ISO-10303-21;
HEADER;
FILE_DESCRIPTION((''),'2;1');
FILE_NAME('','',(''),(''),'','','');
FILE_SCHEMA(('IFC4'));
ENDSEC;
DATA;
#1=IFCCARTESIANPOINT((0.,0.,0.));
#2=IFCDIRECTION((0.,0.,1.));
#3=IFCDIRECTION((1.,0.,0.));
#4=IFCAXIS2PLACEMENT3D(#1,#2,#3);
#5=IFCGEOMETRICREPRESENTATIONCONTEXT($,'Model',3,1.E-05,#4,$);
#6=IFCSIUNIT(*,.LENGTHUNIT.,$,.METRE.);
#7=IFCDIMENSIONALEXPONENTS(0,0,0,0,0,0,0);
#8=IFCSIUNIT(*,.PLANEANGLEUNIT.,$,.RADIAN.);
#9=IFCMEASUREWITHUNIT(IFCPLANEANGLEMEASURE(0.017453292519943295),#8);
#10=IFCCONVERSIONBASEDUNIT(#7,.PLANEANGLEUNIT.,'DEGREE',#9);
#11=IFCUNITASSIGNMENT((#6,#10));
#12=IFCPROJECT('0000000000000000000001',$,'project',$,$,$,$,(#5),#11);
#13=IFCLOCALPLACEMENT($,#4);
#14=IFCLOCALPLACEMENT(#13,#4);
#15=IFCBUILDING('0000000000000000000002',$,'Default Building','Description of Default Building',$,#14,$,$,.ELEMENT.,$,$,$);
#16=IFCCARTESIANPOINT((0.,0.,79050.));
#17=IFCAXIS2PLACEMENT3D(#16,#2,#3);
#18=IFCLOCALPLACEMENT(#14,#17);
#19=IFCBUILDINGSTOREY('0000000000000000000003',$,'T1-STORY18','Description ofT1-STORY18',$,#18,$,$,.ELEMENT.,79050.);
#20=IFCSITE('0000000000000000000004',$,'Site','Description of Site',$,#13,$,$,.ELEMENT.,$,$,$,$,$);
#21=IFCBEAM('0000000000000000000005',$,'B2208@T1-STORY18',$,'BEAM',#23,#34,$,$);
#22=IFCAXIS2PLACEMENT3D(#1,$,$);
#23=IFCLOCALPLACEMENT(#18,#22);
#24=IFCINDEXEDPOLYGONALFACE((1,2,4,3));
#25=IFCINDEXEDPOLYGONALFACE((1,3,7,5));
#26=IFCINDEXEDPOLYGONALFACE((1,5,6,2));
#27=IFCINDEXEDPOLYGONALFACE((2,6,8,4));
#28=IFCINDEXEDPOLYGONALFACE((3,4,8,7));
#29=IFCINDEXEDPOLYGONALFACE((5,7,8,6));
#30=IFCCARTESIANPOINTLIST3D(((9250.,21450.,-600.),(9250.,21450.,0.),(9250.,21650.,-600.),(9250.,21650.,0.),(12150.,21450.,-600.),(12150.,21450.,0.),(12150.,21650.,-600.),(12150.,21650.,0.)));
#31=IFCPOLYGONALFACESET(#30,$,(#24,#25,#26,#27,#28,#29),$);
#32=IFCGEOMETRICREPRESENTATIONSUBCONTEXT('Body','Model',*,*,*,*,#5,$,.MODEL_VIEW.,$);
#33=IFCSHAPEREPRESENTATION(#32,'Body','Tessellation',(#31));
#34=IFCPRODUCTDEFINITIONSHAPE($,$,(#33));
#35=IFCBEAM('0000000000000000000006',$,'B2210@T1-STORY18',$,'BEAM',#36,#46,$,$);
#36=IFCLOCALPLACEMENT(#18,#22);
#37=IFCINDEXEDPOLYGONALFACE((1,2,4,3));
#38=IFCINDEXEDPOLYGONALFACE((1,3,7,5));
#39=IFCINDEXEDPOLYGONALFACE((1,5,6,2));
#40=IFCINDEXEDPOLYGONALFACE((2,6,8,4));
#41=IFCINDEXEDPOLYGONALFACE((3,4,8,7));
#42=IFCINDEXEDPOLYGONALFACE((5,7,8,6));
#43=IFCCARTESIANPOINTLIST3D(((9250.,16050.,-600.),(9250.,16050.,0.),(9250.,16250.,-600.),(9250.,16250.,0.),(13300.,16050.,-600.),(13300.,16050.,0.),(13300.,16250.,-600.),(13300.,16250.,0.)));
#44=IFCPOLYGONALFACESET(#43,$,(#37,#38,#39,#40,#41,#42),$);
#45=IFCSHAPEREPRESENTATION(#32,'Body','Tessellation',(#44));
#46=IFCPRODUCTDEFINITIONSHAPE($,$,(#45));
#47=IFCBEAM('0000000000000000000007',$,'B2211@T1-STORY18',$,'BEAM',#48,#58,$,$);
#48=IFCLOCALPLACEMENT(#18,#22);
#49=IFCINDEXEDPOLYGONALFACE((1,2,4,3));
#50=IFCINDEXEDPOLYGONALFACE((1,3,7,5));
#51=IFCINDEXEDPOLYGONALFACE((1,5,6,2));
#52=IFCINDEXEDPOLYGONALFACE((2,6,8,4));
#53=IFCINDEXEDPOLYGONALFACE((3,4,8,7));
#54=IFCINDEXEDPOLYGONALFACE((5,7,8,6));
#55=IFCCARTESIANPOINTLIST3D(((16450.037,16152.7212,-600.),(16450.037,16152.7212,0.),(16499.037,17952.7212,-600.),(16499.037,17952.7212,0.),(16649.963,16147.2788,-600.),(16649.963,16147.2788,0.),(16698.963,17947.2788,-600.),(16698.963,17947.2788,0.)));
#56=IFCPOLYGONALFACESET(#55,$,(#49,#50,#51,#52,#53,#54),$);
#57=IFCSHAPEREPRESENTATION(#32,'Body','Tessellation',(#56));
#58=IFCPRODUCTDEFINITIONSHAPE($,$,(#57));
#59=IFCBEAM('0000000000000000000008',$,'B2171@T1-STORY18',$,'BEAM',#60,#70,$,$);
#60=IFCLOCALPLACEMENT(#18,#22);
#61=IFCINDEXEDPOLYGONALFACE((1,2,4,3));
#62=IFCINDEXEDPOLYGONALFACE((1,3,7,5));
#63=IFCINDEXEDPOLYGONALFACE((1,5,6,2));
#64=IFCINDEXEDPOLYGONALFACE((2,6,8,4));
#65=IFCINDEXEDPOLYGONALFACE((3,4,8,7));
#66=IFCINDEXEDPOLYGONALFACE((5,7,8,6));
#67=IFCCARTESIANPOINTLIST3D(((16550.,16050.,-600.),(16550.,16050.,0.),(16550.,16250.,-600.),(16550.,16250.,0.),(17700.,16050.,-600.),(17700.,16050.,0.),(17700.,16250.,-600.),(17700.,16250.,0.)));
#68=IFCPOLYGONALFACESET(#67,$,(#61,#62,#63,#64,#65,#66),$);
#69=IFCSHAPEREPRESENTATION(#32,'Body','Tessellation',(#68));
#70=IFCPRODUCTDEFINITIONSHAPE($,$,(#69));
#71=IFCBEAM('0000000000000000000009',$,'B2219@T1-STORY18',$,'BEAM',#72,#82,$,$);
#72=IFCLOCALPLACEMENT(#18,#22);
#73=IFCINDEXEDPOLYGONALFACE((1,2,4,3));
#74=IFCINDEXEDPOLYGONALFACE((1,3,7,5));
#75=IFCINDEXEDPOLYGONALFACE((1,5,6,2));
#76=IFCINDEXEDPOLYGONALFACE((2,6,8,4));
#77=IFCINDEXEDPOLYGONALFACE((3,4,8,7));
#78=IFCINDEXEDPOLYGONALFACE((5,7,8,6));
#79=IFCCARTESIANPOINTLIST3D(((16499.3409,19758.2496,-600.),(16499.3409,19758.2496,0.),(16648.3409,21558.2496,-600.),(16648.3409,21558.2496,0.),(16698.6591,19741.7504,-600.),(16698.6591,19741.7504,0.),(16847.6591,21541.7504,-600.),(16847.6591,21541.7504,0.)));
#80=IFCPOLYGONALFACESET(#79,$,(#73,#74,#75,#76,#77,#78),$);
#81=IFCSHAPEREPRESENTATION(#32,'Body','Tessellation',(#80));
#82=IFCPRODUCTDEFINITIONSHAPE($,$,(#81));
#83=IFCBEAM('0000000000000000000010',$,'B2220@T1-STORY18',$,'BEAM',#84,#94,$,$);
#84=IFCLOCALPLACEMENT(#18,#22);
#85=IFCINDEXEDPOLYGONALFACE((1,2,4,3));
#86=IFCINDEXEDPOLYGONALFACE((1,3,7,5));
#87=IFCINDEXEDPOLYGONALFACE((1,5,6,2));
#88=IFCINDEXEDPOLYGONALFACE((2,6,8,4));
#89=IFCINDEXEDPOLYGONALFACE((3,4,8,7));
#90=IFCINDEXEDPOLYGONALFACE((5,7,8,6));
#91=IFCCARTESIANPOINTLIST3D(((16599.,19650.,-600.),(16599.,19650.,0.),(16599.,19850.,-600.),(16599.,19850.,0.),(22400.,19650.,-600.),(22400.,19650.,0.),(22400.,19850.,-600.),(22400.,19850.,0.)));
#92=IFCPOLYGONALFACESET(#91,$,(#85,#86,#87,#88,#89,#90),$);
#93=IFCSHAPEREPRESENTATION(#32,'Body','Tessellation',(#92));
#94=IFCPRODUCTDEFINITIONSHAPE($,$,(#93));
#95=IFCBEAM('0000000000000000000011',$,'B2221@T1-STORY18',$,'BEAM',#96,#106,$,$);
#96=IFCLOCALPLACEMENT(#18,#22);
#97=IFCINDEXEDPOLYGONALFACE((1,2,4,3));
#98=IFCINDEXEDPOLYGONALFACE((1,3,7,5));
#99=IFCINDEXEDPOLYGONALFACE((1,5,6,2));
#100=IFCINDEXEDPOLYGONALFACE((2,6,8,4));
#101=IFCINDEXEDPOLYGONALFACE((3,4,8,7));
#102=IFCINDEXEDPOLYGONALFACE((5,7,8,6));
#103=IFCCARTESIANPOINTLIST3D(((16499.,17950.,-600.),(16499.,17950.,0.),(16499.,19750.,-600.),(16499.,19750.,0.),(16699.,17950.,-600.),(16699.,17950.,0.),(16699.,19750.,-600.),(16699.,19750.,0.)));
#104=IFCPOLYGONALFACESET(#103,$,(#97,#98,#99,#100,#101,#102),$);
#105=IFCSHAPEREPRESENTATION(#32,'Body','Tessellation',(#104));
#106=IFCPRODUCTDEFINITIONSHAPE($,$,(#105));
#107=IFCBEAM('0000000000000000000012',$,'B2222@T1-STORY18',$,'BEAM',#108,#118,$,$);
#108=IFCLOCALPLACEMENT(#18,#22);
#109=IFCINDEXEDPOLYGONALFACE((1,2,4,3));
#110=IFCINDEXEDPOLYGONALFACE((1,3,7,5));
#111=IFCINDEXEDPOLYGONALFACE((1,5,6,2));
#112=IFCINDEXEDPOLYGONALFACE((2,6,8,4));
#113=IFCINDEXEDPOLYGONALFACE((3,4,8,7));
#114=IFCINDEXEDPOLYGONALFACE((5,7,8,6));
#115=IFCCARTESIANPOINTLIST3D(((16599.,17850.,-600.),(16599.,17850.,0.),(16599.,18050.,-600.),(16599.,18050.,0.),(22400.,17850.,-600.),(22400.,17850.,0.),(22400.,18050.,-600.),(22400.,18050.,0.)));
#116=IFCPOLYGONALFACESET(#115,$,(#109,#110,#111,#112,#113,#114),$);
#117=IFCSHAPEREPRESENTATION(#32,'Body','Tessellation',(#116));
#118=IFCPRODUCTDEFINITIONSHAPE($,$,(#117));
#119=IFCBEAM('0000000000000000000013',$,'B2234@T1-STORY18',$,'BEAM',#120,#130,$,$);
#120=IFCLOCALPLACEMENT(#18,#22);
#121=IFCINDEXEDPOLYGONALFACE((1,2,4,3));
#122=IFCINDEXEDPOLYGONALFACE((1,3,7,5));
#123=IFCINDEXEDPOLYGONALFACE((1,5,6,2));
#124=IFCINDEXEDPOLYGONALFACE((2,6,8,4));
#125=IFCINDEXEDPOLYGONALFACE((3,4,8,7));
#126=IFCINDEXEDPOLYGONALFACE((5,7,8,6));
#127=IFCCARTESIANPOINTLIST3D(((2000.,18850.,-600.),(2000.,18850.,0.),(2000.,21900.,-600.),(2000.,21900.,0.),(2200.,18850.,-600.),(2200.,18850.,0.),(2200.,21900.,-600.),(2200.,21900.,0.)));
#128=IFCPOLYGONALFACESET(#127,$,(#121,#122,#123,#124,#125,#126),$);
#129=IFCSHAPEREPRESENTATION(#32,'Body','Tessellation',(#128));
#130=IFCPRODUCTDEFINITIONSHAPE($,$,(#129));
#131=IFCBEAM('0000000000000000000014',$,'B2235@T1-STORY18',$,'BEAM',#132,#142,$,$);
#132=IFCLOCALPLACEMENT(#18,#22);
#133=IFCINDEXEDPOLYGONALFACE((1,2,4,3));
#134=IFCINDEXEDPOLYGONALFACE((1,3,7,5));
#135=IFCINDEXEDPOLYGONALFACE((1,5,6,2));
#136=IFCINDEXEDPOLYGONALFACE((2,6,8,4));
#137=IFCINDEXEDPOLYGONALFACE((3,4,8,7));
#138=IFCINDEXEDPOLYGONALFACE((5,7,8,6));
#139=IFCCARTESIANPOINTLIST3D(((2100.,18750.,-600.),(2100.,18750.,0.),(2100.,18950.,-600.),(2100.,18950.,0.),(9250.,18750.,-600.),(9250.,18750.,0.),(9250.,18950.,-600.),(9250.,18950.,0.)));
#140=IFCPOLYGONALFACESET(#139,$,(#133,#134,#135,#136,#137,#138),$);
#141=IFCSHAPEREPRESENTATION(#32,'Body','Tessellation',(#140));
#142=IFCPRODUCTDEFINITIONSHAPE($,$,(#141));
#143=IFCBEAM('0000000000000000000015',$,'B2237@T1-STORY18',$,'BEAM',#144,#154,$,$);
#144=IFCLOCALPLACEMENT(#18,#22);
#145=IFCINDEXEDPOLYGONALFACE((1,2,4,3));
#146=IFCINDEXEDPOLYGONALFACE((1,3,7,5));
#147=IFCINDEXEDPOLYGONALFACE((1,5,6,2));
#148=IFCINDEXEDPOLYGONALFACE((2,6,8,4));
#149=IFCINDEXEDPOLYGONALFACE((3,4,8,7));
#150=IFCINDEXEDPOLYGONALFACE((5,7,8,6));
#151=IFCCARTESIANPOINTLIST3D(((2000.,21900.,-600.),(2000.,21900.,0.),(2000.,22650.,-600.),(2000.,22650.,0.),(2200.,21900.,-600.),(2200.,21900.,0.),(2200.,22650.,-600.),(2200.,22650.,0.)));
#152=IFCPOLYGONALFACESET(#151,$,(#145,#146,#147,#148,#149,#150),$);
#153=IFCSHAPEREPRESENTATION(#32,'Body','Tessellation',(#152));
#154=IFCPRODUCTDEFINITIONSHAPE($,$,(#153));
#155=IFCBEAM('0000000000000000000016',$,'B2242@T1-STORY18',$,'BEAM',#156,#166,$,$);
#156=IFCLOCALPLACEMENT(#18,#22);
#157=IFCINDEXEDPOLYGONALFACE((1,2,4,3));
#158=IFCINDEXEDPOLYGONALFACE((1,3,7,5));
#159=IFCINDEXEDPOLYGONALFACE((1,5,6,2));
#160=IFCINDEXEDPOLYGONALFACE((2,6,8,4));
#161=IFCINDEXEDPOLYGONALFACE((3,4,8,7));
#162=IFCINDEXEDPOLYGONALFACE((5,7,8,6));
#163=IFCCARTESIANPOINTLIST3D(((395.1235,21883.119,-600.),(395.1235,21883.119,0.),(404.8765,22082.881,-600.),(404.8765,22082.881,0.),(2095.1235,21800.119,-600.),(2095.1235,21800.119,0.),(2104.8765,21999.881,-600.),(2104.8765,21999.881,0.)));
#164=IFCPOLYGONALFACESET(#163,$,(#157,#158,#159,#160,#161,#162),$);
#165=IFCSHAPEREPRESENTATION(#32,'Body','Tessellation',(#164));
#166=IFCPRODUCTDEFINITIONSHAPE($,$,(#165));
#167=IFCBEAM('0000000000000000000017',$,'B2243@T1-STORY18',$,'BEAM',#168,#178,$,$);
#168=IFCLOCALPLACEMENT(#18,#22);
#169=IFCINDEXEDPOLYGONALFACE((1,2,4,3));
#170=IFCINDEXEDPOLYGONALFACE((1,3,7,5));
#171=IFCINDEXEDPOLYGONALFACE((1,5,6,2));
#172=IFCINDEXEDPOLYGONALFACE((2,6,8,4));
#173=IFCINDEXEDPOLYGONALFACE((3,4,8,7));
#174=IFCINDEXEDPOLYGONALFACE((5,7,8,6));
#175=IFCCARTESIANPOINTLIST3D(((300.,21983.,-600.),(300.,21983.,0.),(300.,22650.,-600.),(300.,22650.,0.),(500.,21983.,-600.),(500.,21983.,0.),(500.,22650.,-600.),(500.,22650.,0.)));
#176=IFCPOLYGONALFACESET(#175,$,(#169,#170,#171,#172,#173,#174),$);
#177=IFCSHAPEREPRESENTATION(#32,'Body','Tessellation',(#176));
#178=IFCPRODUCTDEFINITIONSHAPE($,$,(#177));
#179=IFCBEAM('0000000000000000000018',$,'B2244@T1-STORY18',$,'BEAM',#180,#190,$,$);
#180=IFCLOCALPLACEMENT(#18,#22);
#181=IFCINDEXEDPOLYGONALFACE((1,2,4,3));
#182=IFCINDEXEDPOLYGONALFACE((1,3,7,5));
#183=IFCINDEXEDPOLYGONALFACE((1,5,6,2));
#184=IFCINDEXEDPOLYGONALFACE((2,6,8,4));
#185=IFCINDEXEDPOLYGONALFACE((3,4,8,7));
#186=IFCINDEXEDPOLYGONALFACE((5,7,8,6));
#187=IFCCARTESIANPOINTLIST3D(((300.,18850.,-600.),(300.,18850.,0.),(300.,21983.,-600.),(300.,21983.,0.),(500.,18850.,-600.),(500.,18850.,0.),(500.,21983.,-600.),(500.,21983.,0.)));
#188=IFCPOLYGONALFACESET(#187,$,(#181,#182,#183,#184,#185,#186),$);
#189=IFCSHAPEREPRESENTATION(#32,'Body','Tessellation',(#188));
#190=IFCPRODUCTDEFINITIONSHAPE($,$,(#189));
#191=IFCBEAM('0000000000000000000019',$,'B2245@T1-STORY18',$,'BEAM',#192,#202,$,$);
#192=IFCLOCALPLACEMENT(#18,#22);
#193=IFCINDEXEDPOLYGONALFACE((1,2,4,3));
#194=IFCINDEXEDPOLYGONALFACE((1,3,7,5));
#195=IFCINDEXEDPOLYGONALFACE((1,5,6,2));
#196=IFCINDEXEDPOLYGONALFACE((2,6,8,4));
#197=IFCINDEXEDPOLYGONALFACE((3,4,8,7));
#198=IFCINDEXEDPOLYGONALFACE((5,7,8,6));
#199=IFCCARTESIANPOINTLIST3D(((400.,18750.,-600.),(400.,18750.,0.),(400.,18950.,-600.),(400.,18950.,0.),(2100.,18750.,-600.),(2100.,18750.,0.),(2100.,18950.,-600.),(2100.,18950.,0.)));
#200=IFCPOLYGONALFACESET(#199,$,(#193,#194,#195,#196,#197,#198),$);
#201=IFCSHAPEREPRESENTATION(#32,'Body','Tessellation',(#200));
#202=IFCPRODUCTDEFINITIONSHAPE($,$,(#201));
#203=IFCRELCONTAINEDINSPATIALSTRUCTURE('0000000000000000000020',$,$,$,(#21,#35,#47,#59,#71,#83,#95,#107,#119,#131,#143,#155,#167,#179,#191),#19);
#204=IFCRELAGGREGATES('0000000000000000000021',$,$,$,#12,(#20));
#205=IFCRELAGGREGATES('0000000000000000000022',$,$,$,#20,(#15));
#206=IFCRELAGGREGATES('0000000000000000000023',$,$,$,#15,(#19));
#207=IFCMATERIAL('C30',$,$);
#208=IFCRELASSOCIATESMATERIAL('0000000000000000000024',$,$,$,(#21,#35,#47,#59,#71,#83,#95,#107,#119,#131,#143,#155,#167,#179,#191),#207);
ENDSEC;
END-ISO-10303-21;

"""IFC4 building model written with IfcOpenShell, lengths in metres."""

from ifc_helpers import new_model, entity, si_unit, converted_unit, frame, origin_with_axes, place, context, subcontext, project, spatial, rectangle, extrude, material, element, save


model = new_model("IFC4")

# Units and contexts
model_context = context("Model", 3, precision=1e-05, world=origin_with_axes())
body_context = subcontext(model_context, "Body", "Model", "MODEL_VIEW")
ifc_project = project(units=[si_unit("LENGTHUNIT", "METRE"), converted_unit("PLANEANGLEUNIT", "DEGREE", entity("IfcPlaneAngleMeasure", 0.017453292519943295), si_unit("PLANEANGLEUNIT", "RADIAN"), dimensions=[0, 0, 0, 0, 0, 0, 0])], contexts=[model_context])

# Site, building, storey
site_placement = place(None, origin_with_axes())
site = spatial("IfcSite", under=ifc_project, at=site_placement, Name="Site", Description="Description of Site", CompositionType="ELEMENT")
building_placement = place(site_placement, origin_with_axes())
building = spatial("IfcBuilding", under=site, at=building_placement, Name="Default Building", Description="Description of Default Building", CompositionType="ELEMENT")
storey_placement = place(building_placement, frame((0.0, 0.0, 79050.0), z_axis=(0.0, 0.0, 1.0), x_axis=(1.0, 0.0, 0.0)))
storey = spatial("IfcBuildingStorey", under=building, at=storey_placement, Name="T1-STORY18", Description="Description ofT1-STORY18", CompositionType="ELEMENT", Elevation=79050.0)

# Beams
ifc_material_1 = material(Name="C30")
beam_1_placement = place(storey_placement, frame((9250.0, 21550.0, -300.0), z_axis=(1.0, 0.0, 0.0), x_axis=(0.0, 1.0, 0.0)))
element("IfcBeam", 1, at=beam_1_placement, inside=storey, material=ifc_material_1, Name="B2208@T1-STORY18", ObjectType="BEAM", context=body_context, shape_type="SweptSolid", body=[
    extrude(rectangle(XDim=200.0, YDim=600.0), origin_with_axes(), (0.0, 0.0, 1.0), 2900.0),
])
beam_2_placement = place(storey_placement, frame((9250.0, 16150.0, -300.0), z_axis=(1.0, 0.0, 0.0), x_axis=(0.0, 1.0, 0.0)))
element("IfcBeam", 2, at=beam_2_placement, inside=storey, material=ifc_material_1, Name="B2210@T1-STORY18", ObjectType="BEAM", context=body_context, shape_type="SweptSolid", body=[
    extrude(rectangle(XDim=200.0, YDim=600.0), origin_with_axes(), (0.0, 0.0, 1.0), 4050.0),
])
beam_3_placement = place(storey_placement, frame((16550.0, 16150.0, -300.0), z_axis=(0.027212, 0.99963, 0.0), x_axis=(-0.99963, 0.027212, 0.0)))
element("IfcBeam", 3, at=beam_3_placement, inside=storey, material=ifc_material_1, Name="B2211@T1-STORY18", ObjectType="BEAM", context=body_context, shape_type="SweptSolid", body=[
    extrude(rectangle(XDim=200.0, YDim=600.0), origin_with_axes(), (0.0, 0.0, 1.0), 1800.6668),
])
beam_4_placement = place(storey_placement, frame((16550.0, 16150.0, -300.0), z_axis=(1.0, 0.0, 0.0), x_axis=(0.0, 1.0, 0.0)))
element("IfcBeam", 4, at=beam_4_placement, inside=storey, material=ifc_material_1, Name="B2171@T1-STORY18", ObjectType="BEAM", context=body_context, shape_type="SweptSolid", body=[
    extrude(rectangle(XDim=200.0, YDim=600.0), origin_with_axes(), (0.0, 0.0, 1.0), 1150.0),
])
beam_5_placement = place(storey_placement, frame((16599.0, 19750.0, -300.0), z_axis=(0.082496, 0.996591, 0.0), x_axis=(-0.996591, 0.082496, 0.0)))
element("IfcBeam", 5, at=beam_5_placement, inside=storey, material=ifc_material_1, Name="B2219@T1-STORY18", ObjectType="BEAM", context=body_context, shape_type="SweptSolid", body=[
    extrude(rectangle(XDim=200.0, YDim=600.0), origin_with_axes(), (0.0, 0.0, 1.0), 1806.1564),
])
beam_6_placement = place(storey_placement, frame((16599.0, 19750.0, -300.0), z_axis=(1.0, 0.0, 0.0), x_axis=(0.0, 1.0, 0.0)))
element("IfcBeam", 6, at=beam_6_placement, inside=storey, material=ifc_material_1, Name="B2220@T1-STORY18", ObjectType="BEAM", context=body_context, shape_type="SweptSolid", body=[
    extrude(rectangle(XDim=200.0, YDim=600.0), origin_with_axes(), (0.0, 0.0, 1.0), 5801.0),
])
beam_7_placement = place(storey_placement, frame((16599.0, 17950.0, -300.0), z_axis=(0.0, 1.0, 0.0), x_axis=(-1.0, 0.0, 0.0)))
element("IfcBeam", 7, at=beam_7_placement, inside=storey, material=ifc_material_1, Name="B2221@T1-STORY18", ObjectType="BEAM", context=body_context, shape_type="SweptSolid", body=[
    extrude(rectangle(XDim=200.0, YDim=600.0), origin_with_axes(), (0.0, 0.0, 1.0), 1800.0),
])
beam_8_placement = place(storey_placement, frame((16599.0, 17950.0, -300.0), z_axis=(1.0, 0.0, 0.0), x_axis=(0.0, 1.0, 0.0)))
element("IfcBeam", 8, at=beam_8_placement, inside=storey, material=ifc_material_1, Name="B2222@T1-STORY18", ObjectType="BEAM", context=body_context, shape_type="SweptSolid", body=[
    extrude(rectangle(XDim=200.0, YDim=600.0), origin_with_axes(), (0.0, 0.0, 1.0), 5801.0),
])
beam_9_placement = place(storey_placement, frame((2100.0, 18850.0, -300.0), z_axis=(0.0, 1.0, 0.0), x_axis=(-1.0, 0.0, 0.0)))
element("IfcBeam", 9, at=beam_9_placement, inside=storey, material=ifc_material_1, Name="B2234@T1-STORY18", ObjectType="BEAM", context=body_context, shape_type="SweptSolid", body=[
    extrude(rectangle(XDim=200.0, YDim=600.0), origin_with_axes(), (0.0, 0.0, 1.0), 3050.0),
])
beam_10_placement = place(storey_placement, frame((2100.0, 18850.0, -300.0), z_axis=(1.0, 0.0, 0.0), x_axis=(0.0, 1.0, 0.0)))
element("IfcBeam", 10, at=beam_10_placement, inside=storey, material=ifc_material_1, Name="B2235@T1-STORY18", ObjectType="BEAM", context=body_context, shape_type="SweptSolid", body=[
    extrude(rectangle(XDim=200.0, YDim=600.0), origin_with_axes(), (0.0, 0.0, 1.0), 7150.0),
])
beam_11_placement = place(storey_placement, frame((2100.0, 21900.0, -300.0), z_axis=(0.0, 1.0, 0.0), x_axis=(-1.0, 0.0, 0.0)))
element("IfcBeam", 11, at=beam_11_placement, inside=storey, material=ifc_material_1, Name="B2237@T1-STORY18", ObjectType="BEAM", context=body_context, shape_type="SweptSolid", body=[
    extrude(rectangle(XDim=200.0, YDim=600.0), origin_with_axes(), (0.0, 0.0, 1.0), 750.0),
])
beam_12_placement = place(storey_placement, frame((400.0, 21983.0, -300.0), z_axis=(0.99881, -0.048765, 0.0), x_axis=(0.048765, 0.99881, 0.0)))
element("IfcBeam", 12, at=beam_12_placement, inside=storey, material=ifc_material_1, Name="B2242@T1-STORY18", ObjectType="BEAM", context=body_context, shape_type="SweptSolid", body=[
    extrude(rectangle(XDim=200.0, YDim=600.0), origin_with_axes(), (0.0, 0.0, 1.0), 1702.025),
])
beam_13_placement = place(storey_placement, frame((400.0, 21983.0, -300.0), z_axis=(0.0, 1.0, 0.0), x_axis=(-1.0, 0.0, 0.0)))
element("IfcBeam", 13, at=beam_13_placement, inside=storey, material=ifc_material_1, Name="B2243@T1-STORY18", ObjectType="BEAM", context=body_context, shape_type="SweptSolid", body=[
    extrude(rectangle(XDim=200.0, YDim=600.0), origin_with_axes(), (0.0, 0.0, 1.0), 667.0),
])
beam_14_placement = place(storey_placement, frame((400.0, 18850.0, -300.0), z_axis=(0.0, 1.0, 0.0), x_axis=(-1.0, 0.0, 0.0)))
element("IfcBeam", 14, at=beam_14_placement, inside=storey, material=ifc_material_1, Name="B2244@T1-STORY18", ObjectType="BEAM", context=body_context, shape_type="SweptSolid", body=[
    extrude(rectangle(XDim=200.0, YDim=600.0), origin_with_axes(), (0.0, 0.0, 1.0), 3133.0),
])
beam_15_placement = place(storey_placement, frame((400.0, 18850.0, -300.0), z_axis=(1.0, 0.0, 0.0), x_axis=(0.0, 1.0, 0.0)))
element("IfcBeam", 15, at=beam_15_placement, inside=storey, material=ifc_material_1, Name="B2245@T1-STORY18", ObjectType="BEAM", context=body_context, shape_type="SweptSolid", body=[
    extrude(rectangle(XDim=200.0, YDim=600.0), origin_with_axes(), (0.0, 0.0, 1.0), 1700.0),
])

save(model, "model.ifc")
